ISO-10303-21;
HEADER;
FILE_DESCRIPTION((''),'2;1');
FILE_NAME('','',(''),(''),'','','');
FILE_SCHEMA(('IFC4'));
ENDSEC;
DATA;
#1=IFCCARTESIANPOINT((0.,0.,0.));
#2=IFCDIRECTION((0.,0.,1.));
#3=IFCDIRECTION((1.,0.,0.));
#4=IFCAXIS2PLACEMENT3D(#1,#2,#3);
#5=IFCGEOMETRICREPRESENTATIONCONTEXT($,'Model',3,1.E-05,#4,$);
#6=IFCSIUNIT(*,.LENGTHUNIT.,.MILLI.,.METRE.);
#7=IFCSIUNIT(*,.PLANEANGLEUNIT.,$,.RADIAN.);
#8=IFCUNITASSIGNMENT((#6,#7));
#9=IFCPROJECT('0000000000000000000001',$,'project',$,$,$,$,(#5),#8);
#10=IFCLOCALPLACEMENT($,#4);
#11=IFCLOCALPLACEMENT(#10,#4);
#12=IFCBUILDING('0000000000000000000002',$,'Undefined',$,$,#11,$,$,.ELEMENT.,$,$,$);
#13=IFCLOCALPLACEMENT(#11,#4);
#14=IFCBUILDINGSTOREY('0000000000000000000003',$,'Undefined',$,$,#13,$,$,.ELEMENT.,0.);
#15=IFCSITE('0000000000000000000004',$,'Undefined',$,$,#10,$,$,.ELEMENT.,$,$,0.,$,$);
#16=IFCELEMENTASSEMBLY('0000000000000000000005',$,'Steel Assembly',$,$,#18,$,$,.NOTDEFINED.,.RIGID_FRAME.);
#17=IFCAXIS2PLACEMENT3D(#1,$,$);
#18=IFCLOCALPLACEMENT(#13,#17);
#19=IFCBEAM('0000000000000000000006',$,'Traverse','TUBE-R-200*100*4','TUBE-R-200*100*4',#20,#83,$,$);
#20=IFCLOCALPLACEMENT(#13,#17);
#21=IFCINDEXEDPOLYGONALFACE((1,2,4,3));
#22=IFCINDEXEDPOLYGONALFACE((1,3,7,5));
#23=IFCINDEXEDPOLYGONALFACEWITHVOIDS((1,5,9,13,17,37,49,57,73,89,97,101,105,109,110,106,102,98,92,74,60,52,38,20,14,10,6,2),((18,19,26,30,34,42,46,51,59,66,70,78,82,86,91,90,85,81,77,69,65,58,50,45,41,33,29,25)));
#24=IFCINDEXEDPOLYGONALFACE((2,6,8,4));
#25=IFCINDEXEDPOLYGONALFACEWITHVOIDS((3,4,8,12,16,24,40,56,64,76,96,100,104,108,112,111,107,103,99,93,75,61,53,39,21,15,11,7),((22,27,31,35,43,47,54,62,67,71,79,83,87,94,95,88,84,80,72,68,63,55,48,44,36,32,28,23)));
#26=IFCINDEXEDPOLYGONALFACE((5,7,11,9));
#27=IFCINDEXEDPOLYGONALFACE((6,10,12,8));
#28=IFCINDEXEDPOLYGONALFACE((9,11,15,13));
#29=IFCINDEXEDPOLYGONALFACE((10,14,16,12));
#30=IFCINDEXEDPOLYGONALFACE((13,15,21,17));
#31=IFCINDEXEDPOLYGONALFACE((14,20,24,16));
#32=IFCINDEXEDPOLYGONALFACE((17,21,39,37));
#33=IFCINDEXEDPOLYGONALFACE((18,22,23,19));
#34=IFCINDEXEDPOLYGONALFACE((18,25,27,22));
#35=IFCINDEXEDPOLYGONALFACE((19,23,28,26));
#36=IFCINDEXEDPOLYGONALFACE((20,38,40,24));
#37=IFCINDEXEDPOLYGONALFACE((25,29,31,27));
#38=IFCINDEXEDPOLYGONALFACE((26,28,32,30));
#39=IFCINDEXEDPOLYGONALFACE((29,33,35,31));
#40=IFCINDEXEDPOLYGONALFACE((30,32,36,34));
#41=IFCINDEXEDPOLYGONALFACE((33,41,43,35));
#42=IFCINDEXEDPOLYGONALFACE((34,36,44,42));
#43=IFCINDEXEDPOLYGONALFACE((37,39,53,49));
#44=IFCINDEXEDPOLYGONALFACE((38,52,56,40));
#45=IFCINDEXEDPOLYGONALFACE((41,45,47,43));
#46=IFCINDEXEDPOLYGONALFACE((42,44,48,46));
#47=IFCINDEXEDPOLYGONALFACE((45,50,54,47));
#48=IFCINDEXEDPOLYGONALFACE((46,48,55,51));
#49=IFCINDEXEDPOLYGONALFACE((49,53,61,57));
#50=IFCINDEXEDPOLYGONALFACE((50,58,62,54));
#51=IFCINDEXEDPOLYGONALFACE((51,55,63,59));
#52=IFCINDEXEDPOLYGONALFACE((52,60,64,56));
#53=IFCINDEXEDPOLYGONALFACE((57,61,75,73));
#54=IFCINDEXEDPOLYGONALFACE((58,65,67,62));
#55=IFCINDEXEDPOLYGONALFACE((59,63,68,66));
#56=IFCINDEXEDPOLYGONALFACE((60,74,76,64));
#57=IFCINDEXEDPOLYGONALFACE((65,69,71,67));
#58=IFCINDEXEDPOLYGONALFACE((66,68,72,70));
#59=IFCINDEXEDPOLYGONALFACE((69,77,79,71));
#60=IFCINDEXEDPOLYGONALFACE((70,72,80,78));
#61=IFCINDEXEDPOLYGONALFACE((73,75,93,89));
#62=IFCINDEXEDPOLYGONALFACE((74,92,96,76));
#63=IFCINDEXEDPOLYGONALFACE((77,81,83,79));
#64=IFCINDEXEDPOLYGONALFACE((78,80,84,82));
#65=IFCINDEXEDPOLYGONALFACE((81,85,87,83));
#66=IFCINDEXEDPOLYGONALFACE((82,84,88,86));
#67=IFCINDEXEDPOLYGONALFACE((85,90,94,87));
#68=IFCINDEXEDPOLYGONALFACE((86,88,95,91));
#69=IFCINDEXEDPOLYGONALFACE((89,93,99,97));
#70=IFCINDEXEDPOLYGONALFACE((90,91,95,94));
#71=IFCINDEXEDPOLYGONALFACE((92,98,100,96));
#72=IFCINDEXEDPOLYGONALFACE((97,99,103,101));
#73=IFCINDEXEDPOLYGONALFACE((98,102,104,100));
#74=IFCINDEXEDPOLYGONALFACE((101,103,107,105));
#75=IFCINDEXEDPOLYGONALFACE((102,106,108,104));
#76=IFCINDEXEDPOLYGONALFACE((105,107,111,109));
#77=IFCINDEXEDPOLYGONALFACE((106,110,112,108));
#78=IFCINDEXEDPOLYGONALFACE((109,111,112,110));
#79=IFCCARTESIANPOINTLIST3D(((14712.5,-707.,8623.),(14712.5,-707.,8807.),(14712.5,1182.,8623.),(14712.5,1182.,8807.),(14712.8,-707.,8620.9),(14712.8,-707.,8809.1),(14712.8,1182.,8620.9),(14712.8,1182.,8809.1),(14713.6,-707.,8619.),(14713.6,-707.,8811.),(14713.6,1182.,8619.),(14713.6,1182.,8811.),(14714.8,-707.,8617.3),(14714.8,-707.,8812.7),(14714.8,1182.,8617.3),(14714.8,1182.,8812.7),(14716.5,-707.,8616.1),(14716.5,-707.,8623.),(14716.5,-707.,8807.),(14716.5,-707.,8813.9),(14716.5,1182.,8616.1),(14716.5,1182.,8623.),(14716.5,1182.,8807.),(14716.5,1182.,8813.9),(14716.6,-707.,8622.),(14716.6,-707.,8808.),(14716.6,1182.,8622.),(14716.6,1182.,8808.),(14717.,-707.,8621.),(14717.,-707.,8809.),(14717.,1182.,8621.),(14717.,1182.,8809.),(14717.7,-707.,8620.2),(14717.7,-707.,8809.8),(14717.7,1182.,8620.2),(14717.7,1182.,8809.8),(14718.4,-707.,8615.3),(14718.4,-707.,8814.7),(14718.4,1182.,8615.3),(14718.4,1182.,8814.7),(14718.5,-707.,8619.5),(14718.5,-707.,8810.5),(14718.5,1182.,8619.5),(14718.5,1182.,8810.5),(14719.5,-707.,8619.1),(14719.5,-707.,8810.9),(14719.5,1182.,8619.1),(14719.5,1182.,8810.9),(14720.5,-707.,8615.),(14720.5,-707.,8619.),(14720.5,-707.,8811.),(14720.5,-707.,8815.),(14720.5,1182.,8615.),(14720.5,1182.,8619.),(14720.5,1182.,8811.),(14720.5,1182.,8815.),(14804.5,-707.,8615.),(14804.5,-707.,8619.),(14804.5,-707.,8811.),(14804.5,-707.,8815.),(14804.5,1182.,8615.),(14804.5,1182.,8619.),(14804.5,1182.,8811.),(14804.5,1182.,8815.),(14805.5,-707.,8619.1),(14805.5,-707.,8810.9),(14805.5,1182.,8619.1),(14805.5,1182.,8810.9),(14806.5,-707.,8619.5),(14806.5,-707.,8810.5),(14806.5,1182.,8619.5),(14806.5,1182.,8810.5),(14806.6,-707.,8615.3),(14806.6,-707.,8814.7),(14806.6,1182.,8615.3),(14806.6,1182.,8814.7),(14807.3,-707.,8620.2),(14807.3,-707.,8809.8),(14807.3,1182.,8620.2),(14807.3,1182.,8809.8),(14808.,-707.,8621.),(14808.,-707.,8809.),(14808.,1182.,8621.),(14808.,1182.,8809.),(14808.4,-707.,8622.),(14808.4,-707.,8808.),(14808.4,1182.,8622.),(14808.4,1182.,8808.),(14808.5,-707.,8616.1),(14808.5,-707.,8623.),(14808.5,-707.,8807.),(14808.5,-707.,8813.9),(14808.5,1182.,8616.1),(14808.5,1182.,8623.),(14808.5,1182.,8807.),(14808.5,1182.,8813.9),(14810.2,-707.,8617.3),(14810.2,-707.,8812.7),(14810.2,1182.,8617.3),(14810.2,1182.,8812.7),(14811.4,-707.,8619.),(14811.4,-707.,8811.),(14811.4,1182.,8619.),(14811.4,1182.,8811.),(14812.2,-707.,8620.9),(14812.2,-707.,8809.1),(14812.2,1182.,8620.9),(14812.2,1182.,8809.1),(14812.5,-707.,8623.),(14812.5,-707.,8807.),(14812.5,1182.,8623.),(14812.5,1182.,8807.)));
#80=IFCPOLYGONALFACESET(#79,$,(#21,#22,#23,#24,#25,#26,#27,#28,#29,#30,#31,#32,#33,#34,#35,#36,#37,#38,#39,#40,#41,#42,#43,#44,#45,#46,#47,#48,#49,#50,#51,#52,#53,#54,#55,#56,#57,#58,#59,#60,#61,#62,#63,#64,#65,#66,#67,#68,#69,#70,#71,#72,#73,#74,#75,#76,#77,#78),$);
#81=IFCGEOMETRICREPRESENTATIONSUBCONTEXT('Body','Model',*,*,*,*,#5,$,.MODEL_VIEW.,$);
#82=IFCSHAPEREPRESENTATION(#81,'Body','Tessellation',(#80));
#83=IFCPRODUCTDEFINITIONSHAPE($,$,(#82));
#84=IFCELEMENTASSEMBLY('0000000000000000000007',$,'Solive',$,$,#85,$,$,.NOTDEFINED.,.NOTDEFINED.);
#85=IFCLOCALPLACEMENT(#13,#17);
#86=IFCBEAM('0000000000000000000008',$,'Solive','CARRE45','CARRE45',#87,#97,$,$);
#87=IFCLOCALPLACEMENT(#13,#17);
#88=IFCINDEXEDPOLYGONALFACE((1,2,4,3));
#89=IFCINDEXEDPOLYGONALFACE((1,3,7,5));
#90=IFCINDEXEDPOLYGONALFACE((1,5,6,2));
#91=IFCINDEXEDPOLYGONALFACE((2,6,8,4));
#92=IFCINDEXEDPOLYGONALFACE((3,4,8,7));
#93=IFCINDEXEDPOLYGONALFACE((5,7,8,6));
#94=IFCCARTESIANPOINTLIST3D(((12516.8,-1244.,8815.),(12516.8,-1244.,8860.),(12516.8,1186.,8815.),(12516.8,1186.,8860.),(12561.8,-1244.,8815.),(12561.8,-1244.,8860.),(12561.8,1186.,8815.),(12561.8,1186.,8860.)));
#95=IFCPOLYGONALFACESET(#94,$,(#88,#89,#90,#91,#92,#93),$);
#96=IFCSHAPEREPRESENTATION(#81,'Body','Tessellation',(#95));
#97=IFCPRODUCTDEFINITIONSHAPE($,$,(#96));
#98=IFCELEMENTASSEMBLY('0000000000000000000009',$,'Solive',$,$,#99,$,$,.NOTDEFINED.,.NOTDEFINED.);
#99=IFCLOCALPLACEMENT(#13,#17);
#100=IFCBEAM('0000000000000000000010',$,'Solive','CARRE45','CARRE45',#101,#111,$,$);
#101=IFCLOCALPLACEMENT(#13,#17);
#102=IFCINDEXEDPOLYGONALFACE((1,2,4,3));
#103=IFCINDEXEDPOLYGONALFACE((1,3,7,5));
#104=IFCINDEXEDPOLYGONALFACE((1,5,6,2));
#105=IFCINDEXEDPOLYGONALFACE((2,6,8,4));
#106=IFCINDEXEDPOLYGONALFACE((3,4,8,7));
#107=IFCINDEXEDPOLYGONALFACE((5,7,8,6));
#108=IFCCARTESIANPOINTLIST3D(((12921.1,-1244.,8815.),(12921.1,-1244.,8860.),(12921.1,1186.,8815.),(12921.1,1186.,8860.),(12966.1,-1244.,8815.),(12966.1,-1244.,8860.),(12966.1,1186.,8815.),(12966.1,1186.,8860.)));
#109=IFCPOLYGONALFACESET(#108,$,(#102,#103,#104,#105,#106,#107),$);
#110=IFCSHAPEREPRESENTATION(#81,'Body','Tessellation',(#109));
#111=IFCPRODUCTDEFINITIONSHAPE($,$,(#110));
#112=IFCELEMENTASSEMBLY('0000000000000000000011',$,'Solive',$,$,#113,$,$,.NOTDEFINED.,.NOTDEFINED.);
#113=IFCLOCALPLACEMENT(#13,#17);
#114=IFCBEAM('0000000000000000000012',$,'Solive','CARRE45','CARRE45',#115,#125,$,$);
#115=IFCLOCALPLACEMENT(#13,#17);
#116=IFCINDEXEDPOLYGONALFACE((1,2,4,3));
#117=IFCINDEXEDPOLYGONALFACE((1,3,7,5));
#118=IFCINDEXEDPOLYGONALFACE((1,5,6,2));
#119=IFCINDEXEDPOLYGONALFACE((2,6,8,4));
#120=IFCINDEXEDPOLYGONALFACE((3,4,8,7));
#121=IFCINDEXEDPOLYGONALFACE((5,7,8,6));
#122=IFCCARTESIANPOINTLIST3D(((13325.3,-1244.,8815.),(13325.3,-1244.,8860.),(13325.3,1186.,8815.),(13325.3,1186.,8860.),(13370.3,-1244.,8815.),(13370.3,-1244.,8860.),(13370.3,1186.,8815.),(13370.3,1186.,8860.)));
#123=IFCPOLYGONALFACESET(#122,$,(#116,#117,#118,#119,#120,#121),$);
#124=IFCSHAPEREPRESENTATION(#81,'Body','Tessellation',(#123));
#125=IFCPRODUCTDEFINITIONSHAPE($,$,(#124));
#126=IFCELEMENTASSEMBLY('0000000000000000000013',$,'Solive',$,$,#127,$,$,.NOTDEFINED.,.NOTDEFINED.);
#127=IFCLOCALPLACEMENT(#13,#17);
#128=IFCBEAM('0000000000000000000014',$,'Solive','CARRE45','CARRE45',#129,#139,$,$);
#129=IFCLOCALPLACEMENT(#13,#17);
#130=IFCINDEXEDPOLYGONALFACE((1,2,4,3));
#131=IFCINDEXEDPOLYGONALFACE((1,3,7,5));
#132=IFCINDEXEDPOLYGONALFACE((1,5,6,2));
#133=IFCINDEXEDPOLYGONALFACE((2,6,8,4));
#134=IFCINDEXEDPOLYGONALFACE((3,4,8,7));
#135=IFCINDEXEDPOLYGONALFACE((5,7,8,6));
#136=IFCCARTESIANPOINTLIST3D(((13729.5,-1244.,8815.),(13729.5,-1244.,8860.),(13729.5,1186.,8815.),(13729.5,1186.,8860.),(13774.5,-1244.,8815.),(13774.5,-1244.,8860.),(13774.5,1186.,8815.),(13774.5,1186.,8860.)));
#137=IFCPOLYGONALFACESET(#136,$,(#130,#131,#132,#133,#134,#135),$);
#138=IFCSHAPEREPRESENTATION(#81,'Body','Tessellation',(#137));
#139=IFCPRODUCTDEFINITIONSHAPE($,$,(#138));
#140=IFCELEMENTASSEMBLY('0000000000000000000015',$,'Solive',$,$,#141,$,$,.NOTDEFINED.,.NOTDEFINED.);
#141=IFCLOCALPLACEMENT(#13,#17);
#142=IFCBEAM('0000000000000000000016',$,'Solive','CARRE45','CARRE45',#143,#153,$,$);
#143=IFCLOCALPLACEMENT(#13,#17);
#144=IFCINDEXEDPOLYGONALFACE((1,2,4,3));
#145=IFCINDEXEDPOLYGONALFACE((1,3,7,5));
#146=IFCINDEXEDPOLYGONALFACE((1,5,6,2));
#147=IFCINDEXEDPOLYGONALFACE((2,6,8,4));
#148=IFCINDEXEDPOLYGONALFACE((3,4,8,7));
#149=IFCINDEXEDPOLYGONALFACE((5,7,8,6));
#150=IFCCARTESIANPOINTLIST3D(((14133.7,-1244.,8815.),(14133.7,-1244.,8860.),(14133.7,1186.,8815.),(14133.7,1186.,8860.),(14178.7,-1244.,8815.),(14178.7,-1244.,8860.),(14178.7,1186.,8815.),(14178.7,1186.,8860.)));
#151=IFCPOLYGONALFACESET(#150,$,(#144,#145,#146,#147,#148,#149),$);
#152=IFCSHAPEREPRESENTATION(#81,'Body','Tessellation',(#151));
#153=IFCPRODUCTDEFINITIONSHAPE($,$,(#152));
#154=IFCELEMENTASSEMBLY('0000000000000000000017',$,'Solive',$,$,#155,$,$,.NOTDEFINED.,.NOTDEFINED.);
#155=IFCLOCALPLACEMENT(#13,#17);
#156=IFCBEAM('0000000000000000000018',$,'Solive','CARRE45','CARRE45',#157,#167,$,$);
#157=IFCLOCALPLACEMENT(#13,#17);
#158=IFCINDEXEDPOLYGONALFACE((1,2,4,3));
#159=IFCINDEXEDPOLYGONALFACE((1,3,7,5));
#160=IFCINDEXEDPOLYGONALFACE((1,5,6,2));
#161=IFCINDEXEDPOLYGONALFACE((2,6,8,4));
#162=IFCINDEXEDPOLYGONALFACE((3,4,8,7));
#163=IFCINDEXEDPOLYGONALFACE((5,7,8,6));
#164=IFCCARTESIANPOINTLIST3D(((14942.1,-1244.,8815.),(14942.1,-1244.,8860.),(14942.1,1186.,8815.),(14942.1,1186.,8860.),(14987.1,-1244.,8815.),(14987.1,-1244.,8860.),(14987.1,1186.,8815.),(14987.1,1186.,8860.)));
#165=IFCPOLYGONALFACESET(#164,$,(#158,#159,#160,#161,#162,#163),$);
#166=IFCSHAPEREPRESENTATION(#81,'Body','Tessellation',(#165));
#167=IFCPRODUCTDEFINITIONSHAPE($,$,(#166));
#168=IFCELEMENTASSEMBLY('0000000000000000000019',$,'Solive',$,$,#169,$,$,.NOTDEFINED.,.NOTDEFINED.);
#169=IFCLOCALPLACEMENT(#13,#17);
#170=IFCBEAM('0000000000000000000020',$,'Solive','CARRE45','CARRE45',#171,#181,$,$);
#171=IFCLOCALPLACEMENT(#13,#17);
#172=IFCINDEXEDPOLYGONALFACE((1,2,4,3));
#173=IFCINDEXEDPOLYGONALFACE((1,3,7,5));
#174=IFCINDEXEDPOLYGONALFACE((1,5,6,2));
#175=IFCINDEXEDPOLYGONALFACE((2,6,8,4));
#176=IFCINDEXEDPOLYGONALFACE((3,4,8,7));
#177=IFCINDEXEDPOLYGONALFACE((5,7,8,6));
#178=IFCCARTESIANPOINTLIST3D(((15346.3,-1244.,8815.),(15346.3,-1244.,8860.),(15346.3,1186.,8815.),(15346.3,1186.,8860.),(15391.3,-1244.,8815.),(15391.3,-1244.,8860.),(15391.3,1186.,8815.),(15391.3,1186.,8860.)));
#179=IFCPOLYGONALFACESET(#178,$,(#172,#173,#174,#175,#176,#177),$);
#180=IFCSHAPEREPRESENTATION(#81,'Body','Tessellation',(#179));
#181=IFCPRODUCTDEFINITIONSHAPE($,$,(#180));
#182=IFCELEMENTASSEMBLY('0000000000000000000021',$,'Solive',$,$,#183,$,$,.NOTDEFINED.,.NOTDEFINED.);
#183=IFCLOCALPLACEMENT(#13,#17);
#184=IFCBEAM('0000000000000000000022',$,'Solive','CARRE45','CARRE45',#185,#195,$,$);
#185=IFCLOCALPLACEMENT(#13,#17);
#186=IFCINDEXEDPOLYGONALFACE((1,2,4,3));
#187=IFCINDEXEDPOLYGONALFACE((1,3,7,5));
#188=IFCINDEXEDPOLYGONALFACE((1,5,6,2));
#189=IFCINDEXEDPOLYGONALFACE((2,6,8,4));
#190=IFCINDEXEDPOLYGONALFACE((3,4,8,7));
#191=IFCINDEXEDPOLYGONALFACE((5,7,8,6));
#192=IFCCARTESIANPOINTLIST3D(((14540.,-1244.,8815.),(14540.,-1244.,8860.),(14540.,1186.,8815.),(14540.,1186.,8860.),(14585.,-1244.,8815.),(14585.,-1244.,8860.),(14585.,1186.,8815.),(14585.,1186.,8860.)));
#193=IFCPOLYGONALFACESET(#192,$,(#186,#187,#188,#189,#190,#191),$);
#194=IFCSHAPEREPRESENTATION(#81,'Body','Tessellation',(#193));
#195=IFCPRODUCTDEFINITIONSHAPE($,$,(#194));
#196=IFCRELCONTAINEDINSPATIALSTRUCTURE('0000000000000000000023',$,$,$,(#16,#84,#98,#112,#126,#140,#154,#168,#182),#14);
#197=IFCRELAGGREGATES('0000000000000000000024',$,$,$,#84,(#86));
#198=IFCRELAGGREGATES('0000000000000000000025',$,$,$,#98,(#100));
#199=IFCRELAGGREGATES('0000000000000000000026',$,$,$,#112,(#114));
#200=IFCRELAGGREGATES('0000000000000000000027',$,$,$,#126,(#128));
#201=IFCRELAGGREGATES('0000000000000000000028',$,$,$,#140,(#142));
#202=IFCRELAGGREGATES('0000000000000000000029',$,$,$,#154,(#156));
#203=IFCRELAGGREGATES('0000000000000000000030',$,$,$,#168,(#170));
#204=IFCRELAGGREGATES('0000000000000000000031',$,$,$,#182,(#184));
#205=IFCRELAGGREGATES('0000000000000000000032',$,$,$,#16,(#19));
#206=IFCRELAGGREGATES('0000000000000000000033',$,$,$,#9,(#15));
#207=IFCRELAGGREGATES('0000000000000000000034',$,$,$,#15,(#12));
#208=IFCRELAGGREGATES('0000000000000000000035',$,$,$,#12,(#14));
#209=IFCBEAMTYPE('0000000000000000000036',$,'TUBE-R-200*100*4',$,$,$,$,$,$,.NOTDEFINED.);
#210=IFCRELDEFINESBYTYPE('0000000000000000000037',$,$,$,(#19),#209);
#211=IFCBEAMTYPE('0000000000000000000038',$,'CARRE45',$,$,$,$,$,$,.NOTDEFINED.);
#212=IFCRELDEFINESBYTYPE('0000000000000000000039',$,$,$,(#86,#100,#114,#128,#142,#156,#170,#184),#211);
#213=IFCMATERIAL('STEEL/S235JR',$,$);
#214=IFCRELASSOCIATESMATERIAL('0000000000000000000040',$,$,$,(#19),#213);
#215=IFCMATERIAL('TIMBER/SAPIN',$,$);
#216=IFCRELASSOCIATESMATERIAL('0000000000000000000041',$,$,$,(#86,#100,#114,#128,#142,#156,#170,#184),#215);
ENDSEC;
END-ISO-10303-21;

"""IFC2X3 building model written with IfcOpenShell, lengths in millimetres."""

from ifc_helpers import new_model, si_unit, frame, origin_with_axes, origin_2d_with_axis, place, context, subcontext, project, spatial, rectangle, hollow_rectangle, extrude, material, type_object, element, aggregate, save


model = new_model("IFC2X3")

# Units and contexts
model_context = context("Model", 3, precision=1e-05, world=origin_with_axes())
body_context = subcontext(model_context, "Body", "Model", "MODEL_VIEW")
ifc_project = project(units=[si_unit("LENGTHUNIT", "METRE", prefix="MILLI"), si_unit("PLANEANGLEUNIT", "RADIAN")], contexts=[model_context])

# Site, building, storey
site_placement = place(None, origin_with_axes())
site = spatial("IfcSite", under=ifc_project, at=site_placement, Name="Undefined", CompositionType="ELEMENT", RefElevation=0.0)
building_placement = place(site_placement, origin_with_axes())
building = spatial("IfcBuilding", under=site, at=building_placement, Name="Undefined", CompositionType="ELEMENT")
storey_placement = place(building_placement, origin_with_axes())
storey = spatial("IfcBuildingStorey", under=building, at=storey_placement, Name="Undefined", CompositionType="ELEMENT", Elevation=0.0)

# Element assemblies, beams
ifc_material_1 = material(Name="STEEL/S235JR")
beam_type_1 = type_object("IfcBeamType", Name="TUBE-R-200*100*4", PredefinedType="NOTDEFINED")
assembly_1_placement = place(storey_placement, origin_with_axes())
assembly_1 = element("IfcElementAssembly", 1, at=assembly_1_placement, inside=storey, Name="Steel Assembly", AssemblyPlace="NOTDEFINED", PredefinedType="RIGID_FRAME")
beam_1_placement = place(assembly_1_placement, frame((14762.5, 1190.0, 8715.0), z_axis=(0.0, 0.0, 1.0), x_axis=(0.0, -1.0, 0.0)))
beam_1 = element("IfcBeam", 2, at=beam_1_placement, type_object=beam_type_1, material=ifc_material_1, Name="Traverse", Description="TUBE-R-200*100*4", ObjectType="TUBE-R-200*100*4", context=body_context, shape_type="SweptSolid", body=[
    extrude(hollow_rectangle(XDim=100.0, YDim=200.0, WallThickness=4.0, InnerFilletRadius=4.0, OuterFilletRadius=8.0, at=origin_2d_with_axis()), frame((1897.0, 0.0, 0.0), z_axis=(-1.0, 0.0, 0.0), x_axis=(0.0, -1.0, 0.0)), (0.0, 0.0, 1.0), 1889.0),
])
assembly_2_placement = place(storey_placement, origin_with_axes())
assembly_2 = element("IfcElementAssembly", 3, at=assembly_2_placement, inside=storey, Name="Solive", AssemblyPlace="NOTDEFINED", PredefinedType="NOTDEFINED")
ifc_material_2 = material(Name="TIMBER/SAPIN")
beam_type_2 = type_object("IfcBeamType", Name="CARRE45", PredefinedType="NOTDEFINED")
beam_2_placement = place(assembly_2_placement, frame((12539.3, 1186.0, 8837.5), z_axis=(0.0, 0.0, -1.0), x_axis=(0.0, -1.0, 0.0)))
beam_2 = element("IfcBeam", 4, at=beam_2_placement, type_object=beam_type_2, material=ifc_material_2, Name="Solive", Description="CARRE45", ObjectType="CARRE45", context=body_context, shape_type="SweptSolid", body=[
    extrude(rectangle(XDim=45.0, YDim=45.0, at=origin_2d_with_axis()), frame((2430.0, 0.0, 0.0), z_axis=(-1.0, 0.0, 0.0), x_axis=(0.0, -1.0, 0.0)), (0.0, 0.0, 1.0), 2430.0),
])
aggregate(assembly_2, [beam_2])
assembly_3_placement = place(storey_placement, origin_with_axes())
assembly_3 = element("IfcElementAssembly", 5, at=assembly_3_placement, inside=storey, Name="Solive", AssemblyPlace="NOTDEFINED", PredefinedType="NOTDEFINED")
beam_3_placement = place(assembly_3_placement, frame((12943.6, 1186.0, 8837.5), z_axis=(0.0, 0.0, -1.0), x_axis=(0.0, -1.0, 0.0)))
beam_3 = element("IfcBeam", 6, at=beam_3_placement, type_object=beam_type_2, material=ifc_material_2, Name="Solive", Description="CARRE45", ObjectType="CARRE45", context=body_context, shape_type="SweptSolid", body=[
    extrude(rectangle(XDim=45.0, YDim=45.0, at=origin_2d_with_axis()), frame((2430.0, 0.0, 0.0), z_axis=(-1.0, 0.0, 0.0), x_axis=(0.0, -1.0, 0.0)), (0.0, 0.0, 1.0), 2430.0),
])
aggregate(assembly_3, [beam_3])
assembly_4_placement = place(storey_placement, origin_with_axes())
assembly_4 = element("IfcElementAssembly", 7, at=assembly_4_placement, inside=storey, Name="Solive", AssemblyPlace="NOTDEFINED", PredefinedType="NOTDEFINED")
beam_4_placement = place(assembly_4_placement, frame((13347.8, 1186.0, 8837.5), z_axis=(0.0, 0.0, -1.0), x_axis=(0.0, -1.0, 0.0)))
beam_4 = element("IfcBeam", 8, at=beam_4_placement, type_object=beam_type_2, material=ifc_material_2, Name="Solive", Description="CARRE45", ObjectType="CARRE45", context=body_context, shape_type="SweptSolid", body=[
    extrude(rectangle(XDim=45.0, YDim=45.0, at=origin_2d_with_axis()), frame((2430.0, 0.0, 0.0), z_axis=(-1.0, 0.0, 0.0), x_axis=(0.0, -1.0, 0.0)), (0.0, 0.0, 1.0), 2430.0),
])
aggregate(assembly_4, [beam_4])
assembly_5_placement = place(storey_placement, origin_with_axes())
assembly_5 = element("IfcElementAssembly", 9, at=assembly_5_placement, inside=storey, Name="Solive", AssemblyPlace="NOTDEFINED", PredefinedType="NOTDEFINED")
beam_5_placement = place(assembly_5_placement, frame((13752.0, 1186.0, 8837.5), z_axis=(0.0, 0.0, -1.0), x_axis=(0.0, -1.0, 0.0)))
beam_5 = element("IfcBeam", 10, at=beam_5_placement, type_object=beam_type_2, material=ifc_material_2, Name="Solive", Description="CARRE45", ObjectType="CARRE45", context=body_context, shape_type="SweptSolid", body=[
    extrude(rectangle(XDim=45.0, YDim=45.0, at=origin_2d_with_axis()), frame((2430.0, 0.0, 0.0), z_axis=(-1.0, 0.0, 0.0), x_axis=(0.0, -1.0, 0.0)), (0.0, 0.0, 1.0), 2430.0),
])
aggregate(assembly_5, [beam_5])
assembly_6_placement = place(storey_placement, origin_with_axes())
assembly_6 = element("IfcElementAssembly", 11, at=assembly_6_placement, inside=storey, Name="Solive", AssemblyPlace="NOTDEFINED", PredefinedType="NOTDEFINED")
beam_6_placement = place(assembly_6_placement, frame((14156.2, 1186.0, 8837.5), z_axis=(0.0, 0.0, -1.0), x_axis=(0.0, -1.0, 0.0)))
beam_6 = element("IfcBeam", 12, at=beam_6_placement, type_object=beam_type_2, material=ifc_material_2, Name="Solive", Description="CARRE45", ObjectType="CARRE45", context=body_context, shape_type="SweptSolid", body=[
    extrude(rectangle(XDim=45.0, YDim=45.0, at=origin_2d_with_axis()), frame((2430.0, 0.0, 0.0), z_axis=(-1.0, 0.0, 0.0), x_axis=(0.0, -1.0, 0.0)), (0.0, 0.0, 1.0), 2430.0),
])
aggregate(assembly_6, [beam_6])
assembly_7_placement = place(storey_placement, origin_with_axes())
assembly_7 = element("IfcElementAssembly", 13, at=assembly_7_placement, inside=storey, Name="Solive", AssemblyPlace="NOTDEFINED", PredefinedType="NOTDEFINED")
beam_7_placement = place(assembly_7_placement, frame((14964.6, 1186.0, 8837.5), z_axis=(0.0, 0.0, -1.0), x_axis=(0.0, -1.0, 0.0)))
beam_7 = element("IfcBeam", 14, at=beam_7_placement, type_object=beam_type_2, material=ifc_material_2, Name="Solive", Description="CARRE45", ObjectType="CARRE45", context=body_context, shape_type="SweptSolid", body=[
    extrude(rectangle(XDim=45.0, YDim=45.0, at=origin_2d_with_axis()), frame((2430.0, 0.0, 0.0), z_axis=(-1.0, 0.0, 0.0), x_axis=(0.0, -1.0, 0.0)), (0.0, 0.0, 1.0), 2430.0),
])
aggregate(assembly_7, [beam_7])
assembly_8_placement = place(storey_placement, origin_with_axes())
assembly_8 = element("IfcElementAssembly", 15, at=assembly_8_placement, inside=storey, Name="Solive", AssemblyPlace="NOTDEFINED", PredefinedType="NOTDEFINED")
beam_8_placement = place(assembly_8_placement, frame((15368.8, 1186.0, 8837.5), z_axis=(0.0, 0.0, -1.0), x_axis=(0.0, -1.0, 0.0)))
beam_8 = element("IfcBeam", 16, at=beam_8_placement, type_object=beam_type_2, material=ifc_material_2, Name="Solive", Description="CARRE45", ObjectType="CARRE45", context=body_context, shape_type="SweptSolid", body=[
    extrude(rectangle(XDim=45.0, YDim=45.0, at=origin_2d_with_axis()), frame((2430.0, 0.0, 0.0), z_axis=(-1.0, 0.0, 0.0), x_axis=(0.0, -1.0, 0.0)), (0.0, 0.0, 1.0), 2430.0),
])
aggregate(assembly_8, [beam_8])
assembly_9_placement = place(storey_placement, origin_with_axes())
assembly_9 = element("IfcElementAssembly", 17, at=assembly_9_placement, inside=storey, Name="Solive", AssemblyPlace="NOTDEFINED", PredefinedType="NOTDEFINED")
beam_9_placement = place(assembly_9_placement, frame((14562.5, 1186.0, 8837.5), z_axis=(0.0, 0.0, -1.0), x_axis=(0.0, -1.0, 0.0)))
beam_9 = element("IfcBeam", 18, at=beam_9_placement, type_object=beam_type_2, material=ifc_material_2, Name="Solive", Description="CARRE45", ObjectType="CARRE45", context=body_context, shape_type="SweptSolid", body=[
    extrude(rectangle(XDim=45.0, YDim=45.0, at=origin_2d_with_axis()), frame((2430.0, 0.0, 0.0), z_axis=(-1.0, 0.0, 0.0), x_axis=(0.0, -1.0, 0.0)), (0.0, 0.0, 1.0), 2430.0),
])
aggregate(assembly_9, [beam_9])

aggregate(assembly_1, [beam_1])

save(model, "model.ifc")
